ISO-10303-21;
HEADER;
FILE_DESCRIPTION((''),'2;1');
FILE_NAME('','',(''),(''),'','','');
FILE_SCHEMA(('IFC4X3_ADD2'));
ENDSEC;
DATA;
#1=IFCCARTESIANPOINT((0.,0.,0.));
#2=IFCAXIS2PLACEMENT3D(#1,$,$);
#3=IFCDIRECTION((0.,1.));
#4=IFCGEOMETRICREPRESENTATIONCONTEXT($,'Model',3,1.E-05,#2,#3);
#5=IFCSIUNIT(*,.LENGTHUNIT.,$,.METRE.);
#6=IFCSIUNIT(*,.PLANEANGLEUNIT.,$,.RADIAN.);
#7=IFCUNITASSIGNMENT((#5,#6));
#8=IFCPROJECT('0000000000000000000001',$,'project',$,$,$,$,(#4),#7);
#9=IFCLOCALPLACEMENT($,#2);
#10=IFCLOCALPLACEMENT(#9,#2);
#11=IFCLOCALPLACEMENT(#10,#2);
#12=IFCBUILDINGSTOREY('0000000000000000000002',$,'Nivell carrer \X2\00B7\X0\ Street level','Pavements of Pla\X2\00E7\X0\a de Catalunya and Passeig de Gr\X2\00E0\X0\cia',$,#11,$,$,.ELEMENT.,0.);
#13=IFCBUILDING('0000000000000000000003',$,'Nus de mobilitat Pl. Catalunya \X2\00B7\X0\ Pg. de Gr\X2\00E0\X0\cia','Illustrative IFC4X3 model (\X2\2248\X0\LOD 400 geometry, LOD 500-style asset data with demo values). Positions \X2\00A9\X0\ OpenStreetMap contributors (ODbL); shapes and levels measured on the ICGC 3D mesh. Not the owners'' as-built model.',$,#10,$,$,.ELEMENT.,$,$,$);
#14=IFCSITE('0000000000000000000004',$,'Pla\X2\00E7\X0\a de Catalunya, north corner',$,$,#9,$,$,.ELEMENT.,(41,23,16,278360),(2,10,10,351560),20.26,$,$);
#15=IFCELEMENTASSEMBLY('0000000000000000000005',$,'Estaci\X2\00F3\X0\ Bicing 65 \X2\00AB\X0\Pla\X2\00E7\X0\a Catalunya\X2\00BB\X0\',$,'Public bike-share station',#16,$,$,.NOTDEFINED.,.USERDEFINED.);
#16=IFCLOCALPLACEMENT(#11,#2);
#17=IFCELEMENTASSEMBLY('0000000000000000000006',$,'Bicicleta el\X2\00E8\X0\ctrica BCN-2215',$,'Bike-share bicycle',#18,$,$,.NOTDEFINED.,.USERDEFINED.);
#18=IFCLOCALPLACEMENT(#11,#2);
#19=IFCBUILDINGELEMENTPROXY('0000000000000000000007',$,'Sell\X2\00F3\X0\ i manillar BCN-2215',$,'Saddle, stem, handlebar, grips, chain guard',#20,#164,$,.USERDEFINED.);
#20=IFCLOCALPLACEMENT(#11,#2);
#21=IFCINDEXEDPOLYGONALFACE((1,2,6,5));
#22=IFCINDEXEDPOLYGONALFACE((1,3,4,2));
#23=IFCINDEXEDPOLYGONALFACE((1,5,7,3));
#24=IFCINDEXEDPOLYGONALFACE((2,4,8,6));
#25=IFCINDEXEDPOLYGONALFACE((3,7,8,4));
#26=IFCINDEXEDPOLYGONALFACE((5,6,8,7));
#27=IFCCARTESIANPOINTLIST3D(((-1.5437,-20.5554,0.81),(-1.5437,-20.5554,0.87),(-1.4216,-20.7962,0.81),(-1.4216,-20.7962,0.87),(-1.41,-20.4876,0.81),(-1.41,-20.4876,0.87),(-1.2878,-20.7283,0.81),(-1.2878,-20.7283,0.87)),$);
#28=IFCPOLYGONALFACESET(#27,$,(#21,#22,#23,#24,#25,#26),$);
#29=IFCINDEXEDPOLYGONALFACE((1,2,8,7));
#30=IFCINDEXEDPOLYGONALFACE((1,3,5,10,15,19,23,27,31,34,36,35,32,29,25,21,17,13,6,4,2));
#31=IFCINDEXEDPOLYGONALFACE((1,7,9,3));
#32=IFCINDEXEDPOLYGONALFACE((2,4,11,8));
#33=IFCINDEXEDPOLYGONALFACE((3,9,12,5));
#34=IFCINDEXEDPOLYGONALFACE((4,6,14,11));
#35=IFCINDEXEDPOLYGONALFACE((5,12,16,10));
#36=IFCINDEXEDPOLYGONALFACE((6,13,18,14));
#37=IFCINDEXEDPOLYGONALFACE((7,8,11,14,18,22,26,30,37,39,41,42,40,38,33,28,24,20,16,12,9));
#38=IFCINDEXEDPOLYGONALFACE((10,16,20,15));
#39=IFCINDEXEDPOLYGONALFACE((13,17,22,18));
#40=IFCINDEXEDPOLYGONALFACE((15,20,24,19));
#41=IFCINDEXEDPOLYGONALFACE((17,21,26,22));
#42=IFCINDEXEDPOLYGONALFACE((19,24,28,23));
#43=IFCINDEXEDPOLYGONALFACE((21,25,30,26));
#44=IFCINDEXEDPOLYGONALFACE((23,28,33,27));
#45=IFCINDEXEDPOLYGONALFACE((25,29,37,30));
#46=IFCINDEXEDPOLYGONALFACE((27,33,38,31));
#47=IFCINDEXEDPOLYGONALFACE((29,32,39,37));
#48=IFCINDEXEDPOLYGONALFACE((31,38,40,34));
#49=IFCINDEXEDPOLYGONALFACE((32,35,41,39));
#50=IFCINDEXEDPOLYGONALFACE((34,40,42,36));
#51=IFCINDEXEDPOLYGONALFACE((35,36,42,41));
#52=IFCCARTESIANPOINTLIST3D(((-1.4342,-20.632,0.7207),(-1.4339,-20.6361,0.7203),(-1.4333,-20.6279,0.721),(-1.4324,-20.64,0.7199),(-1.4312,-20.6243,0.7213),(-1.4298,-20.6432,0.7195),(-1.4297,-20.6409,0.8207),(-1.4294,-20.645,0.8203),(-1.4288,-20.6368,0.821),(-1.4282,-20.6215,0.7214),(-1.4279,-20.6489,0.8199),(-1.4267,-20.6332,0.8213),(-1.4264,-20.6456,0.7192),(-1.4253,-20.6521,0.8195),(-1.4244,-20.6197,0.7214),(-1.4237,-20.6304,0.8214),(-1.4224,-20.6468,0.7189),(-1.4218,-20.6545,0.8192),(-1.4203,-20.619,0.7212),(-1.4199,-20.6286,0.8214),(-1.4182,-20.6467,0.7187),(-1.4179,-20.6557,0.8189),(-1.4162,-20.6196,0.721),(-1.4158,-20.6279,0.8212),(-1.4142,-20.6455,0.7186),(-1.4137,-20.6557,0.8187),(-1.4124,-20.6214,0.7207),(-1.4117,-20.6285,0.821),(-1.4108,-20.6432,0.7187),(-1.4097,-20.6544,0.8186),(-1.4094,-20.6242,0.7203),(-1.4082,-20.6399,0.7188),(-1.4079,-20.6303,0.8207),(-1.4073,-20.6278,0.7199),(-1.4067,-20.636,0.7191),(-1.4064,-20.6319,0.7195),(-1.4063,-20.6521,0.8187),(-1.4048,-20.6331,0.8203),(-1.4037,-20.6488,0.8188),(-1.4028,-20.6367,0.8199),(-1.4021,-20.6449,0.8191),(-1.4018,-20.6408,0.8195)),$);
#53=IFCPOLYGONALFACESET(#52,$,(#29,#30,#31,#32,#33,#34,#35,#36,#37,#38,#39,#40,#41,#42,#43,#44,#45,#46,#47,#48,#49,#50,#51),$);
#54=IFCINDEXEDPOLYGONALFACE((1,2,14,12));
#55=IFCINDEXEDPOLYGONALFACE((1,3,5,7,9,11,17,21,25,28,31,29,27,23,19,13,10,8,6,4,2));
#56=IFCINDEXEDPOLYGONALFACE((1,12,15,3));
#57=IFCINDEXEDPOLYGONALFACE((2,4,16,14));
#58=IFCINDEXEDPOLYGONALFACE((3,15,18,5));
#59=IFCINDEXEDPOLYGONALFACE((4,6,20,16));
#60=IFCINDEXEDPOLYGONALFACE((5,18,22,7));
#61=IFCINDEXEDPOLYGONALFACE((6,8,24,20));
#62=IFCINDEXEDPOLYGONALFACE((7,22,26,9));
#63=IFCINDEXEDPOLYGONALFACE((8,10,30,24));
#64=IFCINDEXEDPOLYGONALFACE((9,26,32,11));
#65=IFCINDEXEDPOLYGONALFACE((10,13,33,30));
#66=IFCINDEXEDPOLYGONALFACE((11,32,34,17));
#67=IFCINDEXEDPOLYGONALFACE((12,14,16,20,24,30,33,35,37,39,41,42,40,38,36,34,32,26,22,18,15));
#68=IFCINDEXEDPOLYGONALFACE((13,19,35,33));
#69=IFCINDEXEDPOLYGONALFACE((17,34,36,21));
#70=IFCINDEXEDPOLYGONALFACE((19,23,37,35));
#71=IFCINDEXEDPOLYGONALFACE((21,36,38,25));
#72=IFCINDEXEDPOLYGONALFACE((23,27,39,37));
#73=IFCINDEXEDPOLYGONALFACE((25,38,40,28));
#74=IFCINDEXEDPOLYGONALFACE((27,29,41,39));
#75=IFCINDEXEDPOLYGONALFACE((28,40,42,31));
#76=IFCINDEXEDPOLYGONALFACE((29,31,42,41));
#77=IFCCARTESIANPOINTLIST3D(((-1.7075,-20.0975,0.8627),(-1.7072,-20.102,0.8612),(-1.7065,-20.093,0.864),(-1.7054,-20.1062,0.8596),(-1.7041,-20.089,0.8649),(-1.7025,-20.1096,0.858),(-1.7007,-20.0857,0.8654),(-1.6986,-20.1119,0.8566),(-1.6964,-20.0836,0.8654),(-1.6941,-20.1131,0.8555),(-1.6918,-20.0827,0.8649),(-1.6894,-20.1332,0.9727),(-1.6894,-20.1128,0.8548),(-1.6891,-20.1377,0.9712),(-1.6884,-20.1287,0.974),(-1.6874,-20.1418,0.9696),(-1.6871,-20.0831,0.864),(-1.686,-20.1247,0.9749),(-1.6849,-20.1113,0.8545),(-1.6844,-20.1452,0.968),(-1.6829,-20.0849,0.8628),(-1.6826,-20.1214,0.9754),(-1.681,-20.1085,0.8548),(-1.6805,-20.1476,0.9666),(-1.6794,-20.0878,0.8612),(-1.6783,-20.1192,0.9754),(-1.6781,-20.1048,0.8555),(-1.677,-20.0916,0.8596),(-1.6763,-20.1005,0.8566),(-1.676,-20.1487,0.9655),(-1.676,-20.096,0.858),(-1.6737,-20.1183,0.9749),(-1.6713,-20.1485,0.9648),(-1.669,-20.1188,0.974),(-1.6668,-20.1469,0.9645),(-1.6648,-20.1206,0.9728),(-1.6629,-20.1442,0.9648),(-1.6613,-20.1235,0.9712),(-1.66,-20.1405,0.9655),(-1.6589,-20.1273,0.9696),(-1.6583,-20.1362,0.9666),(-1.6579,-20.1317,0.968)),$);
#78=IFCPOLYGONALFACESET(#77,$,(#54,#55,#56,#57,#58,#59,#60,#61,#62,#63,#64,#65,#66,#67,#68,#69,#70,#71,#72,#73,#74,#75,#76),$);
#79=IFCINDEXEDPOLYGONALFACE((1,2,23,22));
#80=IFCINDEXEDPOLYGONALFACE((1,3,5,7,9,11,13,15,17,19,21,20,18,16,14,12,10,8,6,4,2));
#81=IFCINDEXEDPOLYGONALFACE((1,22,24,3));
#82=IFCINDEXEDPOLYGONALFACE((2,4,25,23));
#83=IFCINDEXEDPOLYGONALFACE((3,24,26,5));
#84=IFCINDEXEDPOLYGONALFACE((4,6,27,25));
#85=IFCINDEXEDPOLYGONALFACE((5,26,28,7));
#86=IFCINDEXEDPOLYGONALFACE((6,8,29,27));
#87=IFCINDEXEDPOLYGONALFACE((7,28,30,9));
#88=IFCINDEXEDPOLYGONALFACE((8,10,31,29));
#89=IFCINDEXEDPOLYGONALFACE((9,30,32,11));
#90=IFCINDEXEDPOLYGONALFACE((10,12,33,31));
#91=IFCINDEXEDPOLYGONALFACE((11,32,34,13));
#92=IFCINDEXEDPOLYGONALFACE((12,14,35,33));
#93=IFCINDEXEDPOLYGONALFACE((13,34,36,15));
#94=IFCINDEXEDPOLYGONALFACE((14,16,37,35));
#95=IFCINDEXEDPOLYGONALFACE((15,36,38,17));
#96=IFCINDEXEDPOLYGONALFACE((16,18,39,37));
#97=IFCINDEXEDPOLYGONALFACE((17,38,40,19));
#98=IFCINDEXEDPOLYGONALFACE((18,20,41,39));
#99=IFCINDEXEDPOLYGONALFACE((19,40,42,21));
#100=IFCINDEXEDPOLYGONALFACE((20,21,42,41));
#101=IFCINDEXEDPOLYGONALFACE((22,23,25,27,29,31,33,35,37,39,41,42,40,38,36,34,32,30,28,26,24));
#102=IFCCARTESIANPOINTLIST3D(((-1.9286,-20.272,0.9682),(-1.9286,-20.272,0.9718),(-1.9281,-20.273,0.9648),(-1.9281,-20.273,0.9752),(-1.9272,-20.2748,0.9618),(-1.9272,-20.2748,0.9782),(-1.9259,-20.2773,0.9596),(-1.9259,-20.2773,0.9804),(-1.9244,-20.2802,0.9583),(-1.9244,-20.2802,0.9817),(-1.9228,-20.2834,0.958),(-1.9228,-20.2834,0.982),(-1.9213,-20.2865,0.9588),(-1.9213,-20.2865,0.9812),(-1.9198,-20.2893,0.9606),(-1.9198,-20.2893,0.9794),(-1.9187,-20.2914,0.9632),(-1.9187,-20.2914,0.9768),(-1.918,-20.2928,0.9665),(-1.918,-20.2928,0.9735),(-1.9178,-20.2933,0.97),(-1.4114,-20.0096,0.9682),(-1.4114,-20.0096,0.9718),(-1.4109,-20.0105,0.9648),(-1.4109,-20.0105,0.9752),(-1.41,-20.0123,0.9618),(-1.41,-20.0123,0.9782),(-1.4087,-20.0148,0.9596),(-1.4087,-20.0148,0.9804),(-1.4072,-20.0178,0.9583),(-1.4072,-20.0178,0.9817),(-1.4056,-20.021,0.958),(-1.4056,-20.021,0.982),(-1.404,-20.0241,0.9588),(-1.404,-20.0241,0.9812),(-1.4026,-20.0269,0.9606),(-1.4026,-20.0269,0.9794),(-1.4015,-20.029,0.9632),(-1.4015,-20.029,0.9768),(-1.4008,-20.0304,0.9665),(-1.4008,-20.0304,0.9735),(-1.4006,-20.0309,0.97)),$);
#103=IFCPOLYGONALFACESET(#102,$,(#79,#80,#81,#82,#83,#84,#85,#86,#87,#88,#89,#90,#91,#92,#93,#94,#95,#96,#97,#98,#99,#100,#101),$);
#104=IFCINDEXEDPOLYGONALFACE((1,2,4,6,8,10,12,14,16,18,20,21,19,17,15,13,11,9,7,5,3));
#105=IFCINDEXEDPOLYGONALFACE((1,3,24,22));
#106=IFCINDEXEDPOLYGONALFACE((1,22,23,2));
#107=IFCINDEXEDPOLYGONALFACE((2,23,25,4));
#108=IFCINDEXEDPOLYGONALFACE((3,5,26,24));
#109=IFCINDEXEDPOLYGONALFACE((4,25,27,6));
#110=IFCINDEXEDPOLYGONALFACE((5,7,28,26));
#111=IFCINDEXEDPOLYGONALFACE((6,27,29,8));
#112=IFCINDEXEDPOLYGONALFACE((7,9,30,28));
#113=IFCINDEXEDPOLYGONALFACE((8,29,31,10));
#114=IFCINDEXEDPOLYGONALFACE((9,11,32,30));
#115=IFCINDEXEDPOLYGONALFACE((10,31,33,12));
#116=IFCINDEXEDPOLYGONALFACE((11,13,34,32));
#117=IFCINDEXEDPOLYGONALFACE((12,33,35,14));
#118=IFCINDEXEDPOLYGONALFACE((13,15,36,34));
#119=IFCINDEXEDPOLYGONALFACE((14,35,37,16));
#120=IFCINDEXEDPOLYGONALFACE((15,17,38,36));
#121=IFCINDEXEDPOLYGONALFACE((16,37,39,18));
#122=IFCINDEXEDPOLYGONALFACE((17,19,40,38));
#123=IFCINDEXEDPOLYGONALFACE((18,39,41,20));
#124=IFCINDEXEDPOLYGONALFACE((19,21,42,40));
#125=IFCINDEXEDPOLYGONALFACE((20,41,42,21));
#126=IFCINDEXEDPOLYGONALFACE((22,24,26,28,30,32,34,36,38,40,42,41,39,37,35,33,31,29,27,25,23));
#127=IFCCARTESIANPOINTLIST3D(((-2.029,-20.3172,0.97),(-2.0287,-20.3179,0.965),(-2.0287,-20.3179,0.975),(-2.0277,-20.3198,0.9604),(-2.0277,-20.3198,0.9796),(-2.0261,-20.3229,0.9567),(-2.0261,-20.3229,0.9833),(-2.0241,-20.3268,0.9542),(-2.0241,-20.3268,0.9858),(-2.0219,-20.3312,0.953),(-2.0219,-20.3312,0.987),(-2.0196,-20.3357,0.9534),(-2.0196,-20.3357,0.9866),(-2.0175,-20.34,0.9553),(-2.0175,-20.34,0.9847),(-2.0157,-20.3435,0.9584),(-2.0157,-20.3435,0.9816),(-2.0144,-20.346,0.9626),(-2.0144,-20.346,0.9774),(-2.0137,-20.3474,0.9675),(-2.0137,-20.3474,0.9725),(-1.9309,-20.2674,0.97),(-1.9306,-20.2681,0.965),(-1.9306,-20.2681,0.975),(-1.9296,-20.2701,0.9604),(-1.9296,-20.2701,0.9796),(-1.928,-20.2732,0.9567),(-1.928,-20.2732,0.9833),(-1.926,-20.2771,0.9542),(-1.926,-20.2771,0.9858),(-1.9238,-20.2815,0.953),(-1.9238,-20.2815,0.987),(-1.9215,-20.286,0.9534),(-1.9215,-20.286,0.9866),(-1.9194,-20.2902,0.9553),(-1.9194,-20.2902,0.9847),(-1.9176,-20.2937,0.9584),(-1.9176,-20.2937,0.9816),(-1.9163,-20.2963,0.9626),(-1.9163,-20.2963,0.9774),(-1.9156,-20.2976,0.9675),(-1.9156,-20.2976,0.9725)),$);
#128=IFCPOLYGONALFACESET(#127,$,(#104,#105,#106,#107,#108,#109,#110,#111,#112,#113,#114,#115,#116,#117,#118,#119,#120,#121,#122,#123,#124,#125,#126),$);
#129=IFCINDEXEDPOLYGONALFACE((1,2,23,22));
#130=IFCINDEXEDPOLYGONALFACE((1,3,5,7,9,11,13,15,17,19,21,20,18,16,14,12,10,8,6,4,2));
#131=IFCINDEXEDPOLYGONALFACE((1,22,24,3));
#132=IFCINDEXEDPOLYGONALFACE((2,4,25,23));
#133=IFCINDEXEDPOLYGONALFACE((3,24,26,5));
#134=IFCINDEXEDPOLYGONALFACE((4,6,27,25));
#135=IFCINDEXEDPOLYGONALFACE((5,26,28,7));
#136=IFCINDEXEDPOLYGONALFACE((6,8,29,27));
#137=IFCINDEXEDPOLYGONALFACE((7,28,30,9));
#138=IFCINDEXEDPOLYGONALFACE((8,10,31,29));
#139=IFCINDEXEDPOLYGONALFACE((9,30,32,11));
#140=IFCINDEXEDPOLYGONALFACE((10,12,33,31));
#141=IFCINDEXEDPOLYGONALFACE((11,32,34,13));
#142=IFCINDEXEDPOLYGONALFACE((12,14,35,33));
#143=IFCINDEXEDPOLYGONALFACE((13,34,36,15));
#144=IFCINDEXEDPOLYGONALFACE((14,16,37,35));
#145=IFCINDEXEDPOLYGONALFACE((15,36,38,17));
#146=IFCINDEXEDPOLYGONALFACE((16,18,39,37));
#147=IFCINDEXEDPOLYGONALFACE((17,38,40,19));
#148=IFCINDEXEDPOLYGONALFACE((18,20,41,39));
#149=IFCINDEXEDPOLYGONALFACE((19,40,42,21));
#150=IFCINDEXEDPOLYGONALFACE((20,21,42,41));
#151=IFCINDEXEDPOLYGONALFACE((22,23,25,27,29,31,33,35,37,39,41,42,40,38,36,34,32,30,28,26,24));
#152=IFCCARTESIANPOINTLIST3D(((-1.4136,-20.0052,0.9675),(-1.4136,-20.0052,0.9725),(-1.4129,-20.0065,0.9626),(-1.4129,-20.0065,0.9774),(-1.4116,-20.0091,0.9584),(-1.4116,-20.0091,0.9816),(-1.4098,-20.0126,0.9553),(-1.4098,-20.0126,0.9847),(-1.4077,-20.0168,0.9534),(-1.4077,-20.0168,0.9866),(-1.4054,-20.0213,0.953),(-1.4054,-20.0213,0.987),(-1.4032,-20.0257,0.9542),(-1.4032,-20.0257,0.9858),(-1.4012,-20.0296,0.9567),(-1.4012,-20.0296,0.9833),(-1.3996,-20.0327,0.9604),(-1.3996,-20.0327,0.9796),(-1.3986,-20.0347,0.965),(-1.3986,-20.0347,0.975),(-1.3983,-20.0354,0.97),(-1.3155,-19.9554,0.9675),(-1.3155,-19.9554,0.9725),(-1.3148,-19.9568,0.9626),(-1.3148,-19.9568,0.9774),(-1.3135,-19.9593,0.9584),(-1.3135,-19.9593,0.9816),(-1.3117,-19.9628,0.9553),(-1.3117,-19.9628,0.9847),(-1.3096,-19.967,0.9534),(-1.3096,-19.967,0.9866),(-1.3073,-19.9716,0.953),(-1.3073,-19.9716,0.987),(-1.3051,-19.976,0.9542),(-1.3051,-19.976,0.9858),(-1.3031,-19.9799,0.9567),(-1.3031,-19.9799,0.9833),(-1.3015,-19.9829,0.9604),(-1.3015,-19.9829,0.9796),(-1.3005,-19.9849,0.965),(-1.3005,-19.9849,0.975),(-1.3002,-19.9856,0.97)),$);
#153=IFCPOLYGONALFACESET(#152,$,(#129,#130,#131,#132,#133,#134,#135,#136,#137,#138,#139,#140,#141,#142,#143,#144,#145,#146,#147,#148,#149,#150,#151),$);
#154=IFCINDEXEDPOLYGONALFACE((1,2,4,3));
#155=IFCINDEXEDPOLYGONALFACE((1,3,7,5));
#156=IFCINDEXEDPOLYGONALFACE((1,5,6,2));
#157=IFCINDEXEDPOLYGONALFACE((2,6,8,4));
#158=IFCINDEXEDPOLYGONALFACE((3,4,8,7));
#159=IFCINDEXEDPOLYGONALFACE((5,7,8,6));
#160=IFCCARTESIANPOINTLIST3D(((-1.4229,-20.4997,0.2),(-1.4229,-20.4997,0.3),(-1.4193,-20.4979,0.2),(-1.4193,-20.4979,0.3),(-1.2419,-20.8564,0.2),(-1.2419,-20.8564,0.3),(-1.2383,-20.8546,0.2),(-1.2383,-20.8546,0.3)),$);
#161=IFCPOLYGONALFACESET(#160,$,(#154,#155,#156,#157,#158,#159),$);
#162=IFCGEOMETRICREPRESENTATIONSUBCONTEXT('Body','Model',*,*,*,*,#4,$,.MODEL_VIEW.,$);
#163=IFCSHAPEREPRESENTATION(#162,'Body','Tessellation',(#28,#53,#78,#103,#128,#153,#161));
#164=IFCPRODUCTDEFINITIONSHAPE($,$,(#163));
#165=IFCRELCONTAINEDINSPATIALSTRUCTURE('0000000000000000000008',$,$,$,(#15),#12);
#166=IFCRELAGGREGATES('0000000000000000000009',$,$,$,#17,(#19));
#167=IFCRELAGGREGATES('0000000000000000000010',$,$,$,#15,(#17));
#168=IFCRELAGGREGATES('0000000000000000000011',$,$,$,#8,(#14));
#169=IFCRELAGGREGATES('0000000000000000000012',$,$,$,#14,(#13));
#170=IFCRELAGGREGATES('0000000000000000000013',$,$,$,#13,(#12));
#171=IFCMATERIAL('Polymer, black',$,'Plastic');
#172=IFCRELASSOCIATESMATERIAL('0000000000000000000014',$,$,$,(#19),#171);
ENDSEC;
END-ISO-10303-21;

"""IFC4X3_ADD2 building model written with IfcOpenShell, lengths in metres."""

from ifc_helpers import new_model, si_unit, direction, frame, origin, origin_2d_with_axis, place, context, subcontext, project, spatial, rectangle, circle, extrude, material, element, aggregate, save


model = new_model("IFC4X3_ADD2")

# Units and contexts
model_context = context("Model", 3, precision=1e-05, world=origin(), true_north=direction((0.0, 1.0)))
body_context = subcontext(model_context, "Body", "Model", "MODEL_VIEW")
ifc_project = project(units=[si_unit("LENGTHUNIT", "METRE"), si_unit("PLANEANGLEUNIT", "RADIAN")], contexts=[model_context])

# Site, building, storey
site_placement = place(None, origin())
site = spatial("IfcSite", under=ifc_project, at=site_placement, Name="Plaça de Catalunya, north corner", CompositionType="ELEMENT", RefLatitude=(41, 23, 16, 278360), RefLongitude=(2, 10, 10, 351560), RefElevation=20.26)
building_placement = place(site_placement, origin())
building = spatial("IfcBuilding", under=site, at=building_placement, Name="Nus de mobilitat Pl. Catalunya · Pg. de Gràcia", Description="Illustrative IFC4X3 model (≈LOD 400 geometry, LOD 500-style asset data with demo values). Positions © OpenStreetMap contributors (ODbL); shapes and levels measured on the ICGC 3D mesh. Not the owners' as-built model.", CompositionType="ELEMENT")
storey_placement = place(building_placement, origin())
storey = spatial("IfcBuildingStorey", under=building, at=storey_placement, Name="Nivell carrer · Street level", Description="Pavements of Plaça de Catalunya and Passeig de Gràcia", CompositionType="ELEMENT", Elevation=0.0)

# Element assemblies, building element proxy
assembly_1_placement = place(building_placement, origin())
assembly_1 = element("IfcElementAssembly", 1, at=assembly_1_placement, inside=storey, Name="Estació Bicing 65 «Plaça Catalunya»", ObjectType="Public bike-share station", AssemblyPlace="NOTDEFINED", PredefinedType="USERDEFINED")
assembly_2_placement = place(building_placement, origin())
assembly_2 = element("IfcElementAssembly", 2, at=assembly_2_placement, Name="Bicicleta elèctrica BCN-2215", ObjectType="Bike-share bicycle", AssemblyPlace="NOTDEFINED", PredefinedType="USERDEFINED")
ifc_material_1 = material(Name="Polymer, black", Category="Plastic")
proxy_1_placement = place(building_placement, origin())
proxy_1 = element("IfcBuildingElementProxy", 3, at=proxy_1_placement, material=ifc_material_1, Name="Selló i manillar BCN-2215", ObjectType="Saddle, stem, handlebar, grips, chain guard", PredefinedType="USERDEFINED", context=body_context, shape_type="SweptSolid", body=[
    extrude(rectangle(XDim=0.27, YDim=0.15, at=origin_2d_with_axis()), frame((-1.4158, -20.6419, 0.87), z_axis=(0.0, 0.0, -1.0), x_axis=(-0.452435, 0.891798, 0.0)), (0.0, 0.0, 1.0), 0.06),
    extrude(circle(Radius=0.014, at=origin_2d_with_axis()), frame((-1.4203, -20.633, 0.72), z_axis=(0.045019, -0.088737, 0.995037), x_axis=(0.0, 0.996047, 0.088827)), (0.0, 0.0, 1.0), 0.1005),
    extrude(circle(Radius=0.016, at=origin_2d_with_axis()), frame((-1.6918, -20.0979, 0.86), z_axis=(0.154616, -0.304766, 0.939793), x_axis=(0.0, 0.951232, 0.308475)), (0.0, 0.0, 1.0), 0.117),
    extrude(circle(Radius=0.012, at=origin_2d_with_axis()), frame((-1.9232, -20.2826, 0.97), z_axis=(0.891798, 0.452435, 0.0), x_axis=(0.452435, -0.891798, 0.0)), (0.0, 0.0, 1.0), 0.58),
    extrude(circle(Radius=0.017, at=origin_2d_with_axis()), frame((-1.9232, -20.2826, 0.97), z_axis=(-0.891798, -0.452435, 0.0), x_axis=(-0.452435, 0.891798, 0.0)), (0.0, 0.0, 1.0), 0.11),
    extrude(circle(Radius=0.017, at=origin_2d_with_axis()), frame((-1.406, -20.0202, 0.97), z_axis=(0.891798, 0.452435, 0.0), x_axis=(0.452435, -0.891798, 0.0)), (0.0, 0.0, 1.0), 0.11),
    extrude(rectangle(XDim=0.4, YDim=0.1, at=origin_2d_with_axis()), frame((-1.3324, -20.6781, 0.25), z_axis=(0.891798, 0.452435, 0.0), x_axis=(-0.452435, 0.891798, 0.0)), (0.0, 0.0, 1.0), 0.004),
])
aggregate(assembly_2, [proxy_1])
aggregate(assembly_1, [assembly_2])

save(model, "model.ifc")
